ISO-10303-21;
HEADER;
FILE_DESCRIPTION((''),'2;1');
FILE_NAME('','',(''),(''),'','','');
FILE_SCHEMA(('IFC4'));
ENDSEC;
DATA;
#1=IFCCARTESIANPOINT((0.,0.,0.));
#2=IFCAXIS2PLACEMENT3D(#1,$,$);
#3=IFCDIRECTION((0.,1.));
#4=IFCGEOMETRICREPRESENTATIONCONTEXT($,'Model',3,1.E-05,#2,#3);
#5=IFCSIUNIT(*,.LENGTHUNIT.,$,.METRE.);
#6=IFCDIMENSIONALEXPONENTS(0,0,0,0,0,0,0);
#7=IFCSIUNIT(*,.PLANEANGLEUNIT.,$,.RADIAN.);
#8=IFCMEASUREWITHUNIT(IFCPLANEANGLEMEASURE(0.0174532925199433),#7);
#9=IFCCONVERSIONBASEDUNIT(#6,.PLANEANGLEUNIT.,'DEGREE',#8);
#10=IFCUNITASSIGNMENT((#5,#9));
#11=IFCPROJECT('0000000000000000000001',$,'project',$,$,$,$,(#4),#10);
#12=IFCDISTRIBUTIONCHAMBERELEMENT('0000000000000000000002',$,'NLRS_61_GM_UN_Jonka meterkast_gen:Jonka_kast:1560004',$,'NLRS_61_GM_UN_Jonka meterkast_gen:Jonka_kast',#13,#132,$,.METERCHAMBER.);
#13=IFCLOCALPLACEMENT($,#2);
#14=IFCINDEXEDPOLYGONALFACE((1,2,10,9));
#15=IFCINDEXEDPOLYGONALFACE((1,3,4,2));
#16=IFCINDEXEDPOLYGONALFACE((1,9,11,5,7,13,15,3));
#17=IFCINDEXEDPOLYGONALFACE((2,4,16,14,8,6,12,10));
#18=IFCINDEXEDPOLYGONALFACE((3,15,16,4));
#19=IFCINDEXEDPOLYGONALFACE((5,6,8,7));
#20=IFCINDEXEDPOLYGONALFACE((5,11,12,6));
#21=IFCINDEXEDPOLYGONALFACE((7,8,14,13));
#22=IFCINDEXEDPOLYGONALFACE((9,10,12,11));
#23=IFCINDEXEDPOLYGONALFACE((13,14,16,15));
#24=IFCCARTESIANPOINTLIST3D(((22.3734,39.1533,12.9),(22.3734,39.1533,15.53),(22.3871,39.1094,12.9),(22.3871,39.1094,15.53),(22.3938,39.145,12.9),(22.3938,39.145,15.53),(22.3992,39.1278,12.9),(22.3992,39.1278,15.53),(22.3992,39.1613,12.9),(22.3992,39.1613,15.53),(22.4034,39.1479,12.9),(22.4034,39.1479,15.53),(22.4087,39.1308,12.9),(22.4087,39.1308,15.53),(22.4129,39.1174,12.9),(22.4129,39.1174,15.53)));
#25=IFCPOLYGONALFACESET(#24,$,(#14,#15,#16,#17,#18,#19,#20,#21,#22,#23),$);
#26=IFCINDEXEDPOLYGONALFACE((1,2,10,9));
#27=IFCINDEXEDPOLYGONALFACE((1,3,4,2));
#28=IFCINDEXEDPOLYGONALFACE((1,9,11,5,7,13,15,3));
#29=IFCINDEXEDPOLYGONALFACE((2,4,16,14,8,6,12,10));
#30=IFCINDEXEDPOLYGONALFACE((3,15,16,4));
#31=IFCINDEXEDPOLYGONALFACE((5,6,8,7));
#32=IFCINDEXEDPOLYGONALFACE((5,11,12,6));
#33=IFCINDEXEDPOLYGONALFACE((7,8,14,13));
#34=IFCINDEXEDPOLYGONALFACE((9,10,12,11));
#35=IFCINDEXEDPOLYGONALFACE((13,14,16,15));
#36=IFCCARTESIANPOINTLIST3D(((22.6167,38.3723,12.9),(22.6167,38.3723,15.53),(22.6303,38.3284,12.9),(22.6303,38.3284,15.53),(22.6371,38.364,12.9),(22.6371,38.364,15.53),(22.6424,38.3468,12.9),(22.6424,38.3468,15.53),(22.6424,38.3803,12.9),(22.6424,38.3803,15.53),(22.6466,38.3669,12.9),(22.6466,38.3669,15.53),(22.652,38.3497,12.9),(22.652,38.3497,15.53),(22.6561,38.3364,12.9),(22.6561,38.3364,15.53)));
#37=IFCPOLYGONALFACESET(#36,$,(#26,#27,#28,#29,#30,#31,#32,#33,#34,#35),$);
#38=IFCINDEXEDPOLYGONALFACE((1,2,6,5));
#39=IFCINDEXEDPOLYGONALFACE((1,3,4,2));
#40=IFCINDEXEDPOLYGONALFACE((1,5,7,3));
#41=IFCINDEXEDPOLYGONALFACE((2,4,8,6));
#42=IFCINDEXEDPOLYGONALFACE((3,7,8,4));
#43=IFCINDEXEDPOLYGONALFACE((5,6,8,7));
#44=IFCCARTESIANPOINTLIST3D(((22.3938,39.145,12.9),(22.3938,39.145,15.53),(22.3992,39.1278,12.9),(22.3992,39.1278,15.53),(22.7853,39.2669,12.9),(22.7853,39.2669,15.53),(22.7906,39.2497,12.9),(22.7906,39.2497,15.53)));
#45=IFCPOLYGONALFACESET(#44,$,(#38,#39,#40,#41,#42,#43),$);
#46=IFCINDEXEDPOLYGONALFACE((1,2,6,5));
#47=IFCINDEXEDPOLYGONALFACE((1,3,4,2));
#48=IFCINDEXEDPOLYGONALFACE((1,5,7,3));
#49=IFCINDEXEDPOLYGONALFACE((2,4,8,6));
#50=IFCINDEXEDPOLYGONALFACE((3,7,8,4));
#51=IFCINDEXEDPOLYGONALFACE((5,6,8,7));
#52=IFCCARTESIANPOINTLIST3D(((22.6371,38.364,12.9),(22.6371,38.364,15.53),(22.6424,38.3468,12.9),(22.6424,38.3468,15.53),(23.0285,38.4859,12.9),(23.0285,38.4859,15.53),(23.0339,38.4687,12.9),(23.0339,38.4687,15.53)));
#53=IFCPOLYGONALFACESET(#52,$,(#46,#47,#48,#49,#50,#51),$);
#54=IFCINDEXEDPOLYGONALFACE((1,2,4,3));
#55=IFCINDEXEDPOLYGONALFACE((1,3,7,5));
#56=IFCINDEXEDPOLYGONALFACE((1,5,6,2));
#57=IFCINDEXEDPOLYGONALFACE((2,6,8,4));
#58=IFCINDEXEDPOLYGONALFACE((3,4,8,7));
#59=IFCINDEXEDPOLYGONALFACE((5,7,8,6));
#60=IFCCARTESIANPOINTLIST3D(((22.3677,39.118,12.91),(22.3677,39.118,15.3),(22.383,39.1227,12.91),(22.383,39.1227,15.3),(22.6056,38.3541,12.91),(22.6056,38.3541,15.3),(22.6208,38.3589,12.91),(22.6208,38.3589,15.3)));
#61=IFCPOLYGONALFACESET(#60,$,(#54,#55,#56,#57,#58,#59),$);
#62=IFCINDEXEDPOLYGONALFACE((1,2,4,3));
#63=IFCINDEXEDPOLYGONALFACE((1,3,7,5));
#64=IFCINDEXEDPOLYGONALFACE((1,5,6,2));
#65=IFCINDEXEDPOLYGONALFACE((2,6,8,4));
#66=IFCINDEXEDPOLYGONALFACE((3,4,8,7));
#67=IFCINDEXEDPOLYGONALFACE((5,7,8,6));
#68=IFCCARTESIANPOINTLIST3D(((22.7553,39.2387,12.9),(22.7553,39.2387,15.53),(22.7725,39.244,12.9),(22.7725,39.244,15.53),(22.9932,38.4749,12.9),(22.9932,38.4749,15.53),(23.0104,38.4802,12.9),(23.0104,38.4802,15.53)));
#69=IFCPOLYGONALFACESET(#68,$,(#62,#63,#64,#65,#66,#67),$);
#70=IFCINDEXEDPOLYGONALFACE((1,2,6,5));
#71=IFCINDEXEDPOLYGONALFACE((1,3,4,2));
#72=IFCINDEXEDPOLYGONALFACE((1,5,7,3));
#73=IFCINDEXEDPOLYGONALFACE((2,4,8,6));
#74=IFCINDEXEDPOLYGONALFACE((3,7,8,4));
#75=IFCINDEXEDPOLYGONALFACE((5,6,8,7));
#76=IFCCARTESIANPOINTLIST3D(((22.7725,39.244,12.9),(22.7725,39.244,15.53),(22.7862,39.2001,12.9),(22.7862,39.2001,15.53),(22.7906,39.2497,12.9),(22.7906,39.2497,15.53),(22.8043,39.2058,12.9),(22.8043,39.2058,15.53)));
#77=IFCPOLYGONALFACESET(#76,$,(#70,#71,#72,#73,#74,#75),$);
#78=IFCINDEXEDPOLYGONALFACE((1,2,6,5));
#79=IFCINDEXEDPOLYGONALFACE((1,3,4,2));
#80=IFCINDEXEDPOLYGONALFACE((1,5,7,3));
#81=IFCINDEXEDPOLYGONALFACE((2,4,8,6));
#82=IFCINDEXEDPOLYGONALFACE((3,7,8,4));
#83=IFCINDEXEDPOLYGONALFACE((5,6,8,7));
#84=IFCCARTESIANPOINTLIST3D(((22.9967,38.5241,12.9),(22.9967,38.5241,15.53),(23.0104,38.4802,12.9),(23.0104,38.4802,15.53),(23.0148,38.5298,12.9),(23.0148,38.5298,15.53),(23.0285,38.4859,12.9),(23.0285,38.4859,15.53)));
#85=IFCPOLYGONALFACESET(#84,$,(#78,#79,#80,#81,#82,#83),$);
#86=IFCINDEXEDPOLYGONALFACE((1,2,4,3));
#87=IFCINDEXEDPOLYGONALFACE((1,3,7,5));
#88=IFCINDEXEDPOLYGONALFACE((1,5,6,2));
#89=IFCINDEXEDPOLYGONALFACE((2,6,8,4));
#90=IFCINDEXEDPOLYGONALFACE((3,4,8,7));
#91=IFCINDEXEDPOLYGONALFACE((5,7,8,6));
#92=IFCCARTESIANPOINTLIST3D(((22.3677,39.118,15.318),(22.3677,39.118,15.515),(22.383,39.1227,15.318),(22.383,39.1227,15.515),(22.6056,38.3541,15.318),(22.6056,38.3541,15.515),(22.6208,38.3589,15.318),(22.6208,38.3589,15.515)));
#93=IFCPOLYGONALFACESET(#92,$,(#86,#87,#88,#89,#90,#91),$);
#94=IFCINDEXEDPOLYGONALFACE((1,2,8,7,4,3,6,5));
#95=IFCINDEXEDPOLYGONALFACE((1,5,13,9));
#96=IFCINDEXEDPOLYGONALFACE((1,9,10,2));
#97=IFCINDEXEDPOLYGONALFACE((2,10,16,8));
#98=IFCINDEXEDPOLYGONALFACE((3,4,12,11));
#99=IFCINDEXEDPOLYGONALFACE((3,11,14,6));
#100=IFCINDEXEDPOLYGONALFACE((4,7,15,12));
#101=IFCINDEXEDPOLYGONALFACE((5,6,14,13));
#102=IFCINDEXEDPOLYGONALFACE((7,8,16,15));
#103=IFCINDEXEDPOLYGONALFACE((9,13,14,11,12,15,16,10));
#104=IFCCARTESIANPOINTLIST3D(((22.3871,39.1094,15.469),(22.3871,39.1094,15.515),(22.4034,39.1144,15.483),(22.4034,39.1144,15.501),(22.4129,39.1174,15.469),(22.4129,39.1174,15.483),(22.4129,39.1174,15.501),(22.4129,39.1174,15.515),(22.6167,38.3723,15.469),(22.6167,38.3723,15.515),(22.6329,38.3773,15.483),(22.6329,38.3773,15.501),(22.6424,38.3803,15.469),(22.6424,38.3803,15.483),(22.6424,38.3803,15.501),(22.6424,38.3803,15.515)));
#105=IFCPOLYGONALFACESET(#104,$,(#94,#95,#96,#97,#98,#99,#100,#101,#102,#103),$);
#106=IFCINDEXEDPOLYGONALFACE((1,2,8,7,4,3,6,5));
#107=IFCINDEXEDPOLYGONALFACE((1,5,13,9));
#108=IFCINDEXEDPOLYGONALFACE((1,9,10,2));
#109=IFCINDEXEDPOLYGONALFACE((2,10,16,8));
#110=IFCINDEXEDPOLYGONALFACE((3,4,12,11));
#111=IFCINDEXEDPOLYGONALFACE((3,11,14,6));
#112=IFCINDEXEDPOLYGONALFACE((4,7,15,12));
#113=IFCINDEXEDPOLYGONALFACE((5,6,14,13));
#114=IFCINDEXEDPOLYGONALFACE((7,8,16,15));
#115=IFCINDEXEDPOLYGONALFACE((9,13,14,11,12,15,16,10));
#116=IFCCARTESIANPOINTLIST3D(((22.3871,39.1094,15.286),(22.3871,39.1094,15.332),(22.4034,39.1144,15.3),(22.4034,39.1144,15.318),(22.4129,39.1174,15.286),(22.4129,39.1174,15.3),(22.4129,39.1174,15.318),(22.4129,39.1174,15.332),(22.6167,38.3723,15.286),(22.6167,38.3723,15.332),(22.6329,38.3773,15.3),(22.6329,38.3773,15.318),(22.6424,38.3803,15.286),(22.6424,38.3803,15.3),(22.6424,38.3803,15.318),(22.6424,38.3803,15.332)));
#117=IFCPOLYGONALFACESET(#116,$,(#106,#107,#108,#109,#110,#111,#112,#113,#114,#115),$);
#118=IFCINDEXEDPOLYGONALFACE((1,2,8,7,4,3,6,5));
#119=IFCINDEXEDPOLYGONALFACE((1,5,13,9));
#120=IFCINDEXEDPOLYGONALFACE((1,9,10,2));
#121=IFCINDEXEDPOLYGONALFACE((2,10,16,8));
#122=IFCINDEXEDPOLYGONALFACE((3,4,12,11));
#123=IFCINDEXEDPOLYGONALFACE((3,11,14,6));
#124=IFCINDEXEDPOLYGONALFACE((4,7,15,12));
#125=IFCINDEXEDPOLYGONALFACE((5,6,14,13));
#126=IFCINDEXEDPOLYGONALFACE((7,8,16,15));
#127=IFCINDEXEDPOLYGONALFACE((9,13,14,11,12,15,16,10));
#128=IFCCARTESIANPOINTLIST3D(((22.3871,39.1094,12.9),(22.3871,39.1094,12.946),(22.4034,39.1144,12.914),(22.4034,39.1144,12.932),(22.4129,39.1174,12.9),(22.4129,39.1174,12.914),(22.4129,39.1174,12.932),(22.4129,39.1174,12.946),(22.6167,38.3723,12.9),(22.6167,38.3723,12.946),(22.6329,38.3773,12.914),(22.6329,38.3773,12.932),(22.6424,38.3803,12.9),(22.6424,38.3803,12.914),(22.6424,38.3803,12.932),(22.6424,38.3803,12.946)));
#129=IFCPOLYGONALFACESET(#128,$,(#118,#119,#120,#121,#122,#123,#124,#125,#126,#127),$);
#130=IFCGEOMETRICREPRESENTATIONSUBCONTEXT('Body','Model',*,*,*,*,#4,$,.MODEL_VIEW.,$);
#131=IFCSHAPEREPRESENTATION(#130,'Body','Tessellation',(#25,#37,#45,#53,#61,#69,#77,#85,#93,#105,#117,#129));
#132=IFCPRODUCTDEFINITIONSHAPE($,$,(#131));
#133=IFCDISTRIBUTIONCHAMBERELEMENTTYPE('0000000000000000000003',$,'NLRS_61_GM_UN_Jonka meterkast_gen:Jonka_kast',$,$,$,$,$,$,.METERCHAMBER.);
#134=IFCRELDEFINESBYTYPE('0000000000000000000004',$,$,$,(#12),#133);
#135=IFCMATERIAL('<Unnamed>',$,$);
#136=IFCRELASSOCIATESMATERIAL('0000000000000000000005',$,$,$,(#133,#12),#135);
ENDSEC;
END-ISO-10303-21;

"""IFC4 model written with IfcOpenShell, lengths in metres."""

from ifc_helpers import new_model, entity, si_unit, converted_unit, direction, frame, origin, place, context, subcontext, project, indexed_curve, outline, extrude, source, transform, mapped, material, type_object, type_shapes, element, save


model = new_model("IFC4")

# Units and contexts
model_context = context("Model", 3, precision=1e-05, world=origin(), true_north=direction((0.0, 1.0)))
body_context = subcontext(model_context, "Body", "Model", "MODEL_VIEW")
ifc_project = project(units=[si_unit("LENGTHUNIT", "METRE"), converted_unit("PLANEANGLEUNIT", "DEGREE", entity("IfcPlaneAngleMeasure", 0.0174532925199433), si_unit("PLANEANGLEUNIT", "RADIAN"), dimensions=[0, 0, 0, 0, 0, 0, 0])], contexts=[model_context])

# Distribution chamber element
ifc_material = material(Name="<Unnamed>")
distribution_chamber_element_type = type_object("IfcDistributionChamberElementType", Name="NLRS_61_GM_UN_Jonka meterkast_gen:Jonka_kast", PredefinedType="METERCHAMBER", material=ifc_material)
shared_shape_1 = source(origin(), body_context, "Body", "SweptSolid", [
    extrude(outline(indexed_curve([(-0.0093, -0.023), (0.0178, -0.023), (0.0178, 0.023), (-0.0093, 0.023), (-0.0093, 0.009), (0.0007, 0.009), (0.0007, -0.009), (-0.0093, -0.009), (-0.0093, -0.023)], self_intersect=False)), frame((-0.409, -0.4092, 0.0), z_axis=(0.0, 0.0, 1.0), x_axis=(0.0, -1.0, 0.0)), (0.0, 0.0, 1.0), 2.63),
    extrude(outline(indexed_curve([(-0.0093, -0.023), (0.0178, -0.023), (0.0178, 0.023), (-0.0093, 0.023), (-0.0093, 0.009), (0.0007, 0.009), (0.0007, -0.009), (-0.0093, -0.009), (-0.0093, -0.023)], self_intersect=False)), frame((0.409, -0.4092, 0.0), z_axis=(0.0, 0.0, 1.0), x_axis=(0.0, -1.0, 0.0)), (0.0, 0.0, 1.0), 2.63),
    extrude(outline(indexed_curve([(-0.205, -0.009), (0.205, -0.009), (0.205, 0.009), (-0.205, 0.009), (-0.205, -0.009)], self_intersect=False)), frame((-0.409, -0.205, 0.0), z_axis=(0.0, 0.0, 1.0), x_axis=(0.0, -1.0, 0.0)), (0.0, 0.0, 1.0), 2.63),
    extrude(outline(indexed_curve([(-0.205, -0.009), (0.205, -0.009), (0.205, 0.009), (-0.205, 0.009), (-0.205, -0.009)], self_intersect=False)), frame((0.409, -0.205, 0.0), z_axis=(0.0, 0.0, 1.0), x_axis=(0.0, -1.0, 0.0)), (0.0, 0.0, 1.0), 2.63),
    extrude(outline(indexed_curve([(-0.4, -0.008), (0.4, -0.008), (0.4, 0.008), (-0.4, 0.008), (-0.4, -0.008)], self_intersect=False)), frame((0.0, -0.435, 0.01), z_axis=(0.0, 0.0, 1.0), x_axis=(-1.0, 0.0, 0.0)), (0.0, 0.0, 1.0), 2.39),
    extrude(outline(indexed_curve([(-0.4, -0.009), (0.4, -0.009), (0.4, 0.009), (-0.4, 0.009), (-0.4, -0.009)], self_intersect=False)), frame((0.0, -0.028, 0.0), z_axis=(0.0, 0.0, 1.0), x_axis=(-1.0, 0.0, 0.0)), (0.0, 0.0, 1.0), 2.63),
    extrude(outline(indexed_curve([(-0.023, -0.0095), (0.023, -0.0095), (0.023, 0.0095), (-0.023, 0.0095), (-0.023, -0.0095)], self_intersect=False)), frame((-0.377, -0.0095, 0.0), z_axis=(0.0, 0.0, 1.0), x_axis=(-1.0, 0.0, 0.0)), (0.0, 0.0, 1.0), 2.63),
    extrude(outline(indexed_curve([(-0.023, -0.0095), (0.023, -0.0095), (0.023, 0.0095), (-0.023, 0.0095), (-0.023, -0.0095)], self_intersect=False)), frame((0.377, -0.0095, 0.0), z_axis=(0.0, 0.0, 1.0), x_axis=(-1.0, 0.0, 0.0)), (0.0, 0.0, 1.0), 2.63),
    extrude(outline(indexed_curve([(-0.4, -0.008), (0.4, -0.008), (0.4, 0.008), (-0.4, 0.008), (-0.4, -0.008)], self_intersect=False)), frame((0.0, -0.435, 2.418), z_axis=(0.0, 0.0, 1.0), x_axis=(-1.0, 0.0, 0.0)), (0.0, 0.0, 1.0), 0.197),
    extrude(outline(indexed_curve([(-0.023, -0.0178), (0.023, -0.0178), (0.023, 0.0093), (0.009, 0.0093), (0.009, -0.0007), (-0.009, -0.0007), (-0.009, 0.0093), (-0.023, 0.0093), (-0.023, -0.0178)], self_intersect=False)), frame((-0.386, -0.4092, 2.592), z_axis=(1.0, 0.0, 0.0), x_axis=(0.0, 0.0, -1.0)), (0.0, 0.0, 1.0), 0.772),
    extrude(outline(indexed_curve([(-0.023, -0.0178), (0.023, -0.0178), (0.023, 0.0093), (0.009, 0.0093), (0.009, -0.0007), (-0.009, -0.0007), (-0.009, 0.0093), (-0.023, 0.0093), (-0.023, -0.0178)], self_intersect=False)), frame((-0.386, -0.4092, 2.409), z_axis=(1.0, 0.0, 0.0), x_axis=(0.0, 0.0, -1.0)), (0.0, 0.0, 1.0), 0.772),
    extrude(outline(indexed_curve([(-0.023, -0.0178), (0.023, -0.0178), (0.023, 0.0093), (0.009, 0.0093), (0.009, -0.0007), (-0.009, -0.0007), (-0.009, 0.0093), (-0.023, 0.0093), (-0.023, -0.0178)], self_intersect=False)), frame((-0.386, -0.4092, 0.023), z_axis=(1.0, 0.0, 0.0), x_axis=(0.0, 0.0, -1.0)), (0.0, 0.0, 1.0), 0.772),
])
type_shapes(distribution_chamber_element_type, [shared_shape_1])
placement_1 = place(None, frame((13.1348, 11.9886, 0.0), z_axis=(0.0, 0.0, 1.0), x_axis=(0.954771, 0.297342, 0.0)))
placement_2 = place(placement_1, origin())
placement_3 = place(placement_2, frame((0.0, 0.0, 12.9)))
placement_4 = place(placement_3, origin())
distribution_chamber_element_1_placement = place(placement_4, frame((17.325, 22.757, 0.0), z_axis=(0.0, 0.0, 1.0), x_axis=(0.0, -1.0, 0.0)))
element("IfcDistributionChamberElement", 1, at=distribution_chamber_element_1_placement, type_object=distribution_chamber_element_type, material=ifc_material, Name="NLRS_61_GM_UN_Jonka meterkast_gen:Jonka_kast:1560004", ObjectType="NLRS_61_GM_UN_Jonka meterkast_gen:Jonka_kast", PredefinedType="METERCHAMBER", context=body_context, shape_type="MappedRepresentation", body=[
    mapped(shared_shape_1, transform((0.0, 0.0, 0.0), scale=1.0)),
])

save(model, "model.ifc")
